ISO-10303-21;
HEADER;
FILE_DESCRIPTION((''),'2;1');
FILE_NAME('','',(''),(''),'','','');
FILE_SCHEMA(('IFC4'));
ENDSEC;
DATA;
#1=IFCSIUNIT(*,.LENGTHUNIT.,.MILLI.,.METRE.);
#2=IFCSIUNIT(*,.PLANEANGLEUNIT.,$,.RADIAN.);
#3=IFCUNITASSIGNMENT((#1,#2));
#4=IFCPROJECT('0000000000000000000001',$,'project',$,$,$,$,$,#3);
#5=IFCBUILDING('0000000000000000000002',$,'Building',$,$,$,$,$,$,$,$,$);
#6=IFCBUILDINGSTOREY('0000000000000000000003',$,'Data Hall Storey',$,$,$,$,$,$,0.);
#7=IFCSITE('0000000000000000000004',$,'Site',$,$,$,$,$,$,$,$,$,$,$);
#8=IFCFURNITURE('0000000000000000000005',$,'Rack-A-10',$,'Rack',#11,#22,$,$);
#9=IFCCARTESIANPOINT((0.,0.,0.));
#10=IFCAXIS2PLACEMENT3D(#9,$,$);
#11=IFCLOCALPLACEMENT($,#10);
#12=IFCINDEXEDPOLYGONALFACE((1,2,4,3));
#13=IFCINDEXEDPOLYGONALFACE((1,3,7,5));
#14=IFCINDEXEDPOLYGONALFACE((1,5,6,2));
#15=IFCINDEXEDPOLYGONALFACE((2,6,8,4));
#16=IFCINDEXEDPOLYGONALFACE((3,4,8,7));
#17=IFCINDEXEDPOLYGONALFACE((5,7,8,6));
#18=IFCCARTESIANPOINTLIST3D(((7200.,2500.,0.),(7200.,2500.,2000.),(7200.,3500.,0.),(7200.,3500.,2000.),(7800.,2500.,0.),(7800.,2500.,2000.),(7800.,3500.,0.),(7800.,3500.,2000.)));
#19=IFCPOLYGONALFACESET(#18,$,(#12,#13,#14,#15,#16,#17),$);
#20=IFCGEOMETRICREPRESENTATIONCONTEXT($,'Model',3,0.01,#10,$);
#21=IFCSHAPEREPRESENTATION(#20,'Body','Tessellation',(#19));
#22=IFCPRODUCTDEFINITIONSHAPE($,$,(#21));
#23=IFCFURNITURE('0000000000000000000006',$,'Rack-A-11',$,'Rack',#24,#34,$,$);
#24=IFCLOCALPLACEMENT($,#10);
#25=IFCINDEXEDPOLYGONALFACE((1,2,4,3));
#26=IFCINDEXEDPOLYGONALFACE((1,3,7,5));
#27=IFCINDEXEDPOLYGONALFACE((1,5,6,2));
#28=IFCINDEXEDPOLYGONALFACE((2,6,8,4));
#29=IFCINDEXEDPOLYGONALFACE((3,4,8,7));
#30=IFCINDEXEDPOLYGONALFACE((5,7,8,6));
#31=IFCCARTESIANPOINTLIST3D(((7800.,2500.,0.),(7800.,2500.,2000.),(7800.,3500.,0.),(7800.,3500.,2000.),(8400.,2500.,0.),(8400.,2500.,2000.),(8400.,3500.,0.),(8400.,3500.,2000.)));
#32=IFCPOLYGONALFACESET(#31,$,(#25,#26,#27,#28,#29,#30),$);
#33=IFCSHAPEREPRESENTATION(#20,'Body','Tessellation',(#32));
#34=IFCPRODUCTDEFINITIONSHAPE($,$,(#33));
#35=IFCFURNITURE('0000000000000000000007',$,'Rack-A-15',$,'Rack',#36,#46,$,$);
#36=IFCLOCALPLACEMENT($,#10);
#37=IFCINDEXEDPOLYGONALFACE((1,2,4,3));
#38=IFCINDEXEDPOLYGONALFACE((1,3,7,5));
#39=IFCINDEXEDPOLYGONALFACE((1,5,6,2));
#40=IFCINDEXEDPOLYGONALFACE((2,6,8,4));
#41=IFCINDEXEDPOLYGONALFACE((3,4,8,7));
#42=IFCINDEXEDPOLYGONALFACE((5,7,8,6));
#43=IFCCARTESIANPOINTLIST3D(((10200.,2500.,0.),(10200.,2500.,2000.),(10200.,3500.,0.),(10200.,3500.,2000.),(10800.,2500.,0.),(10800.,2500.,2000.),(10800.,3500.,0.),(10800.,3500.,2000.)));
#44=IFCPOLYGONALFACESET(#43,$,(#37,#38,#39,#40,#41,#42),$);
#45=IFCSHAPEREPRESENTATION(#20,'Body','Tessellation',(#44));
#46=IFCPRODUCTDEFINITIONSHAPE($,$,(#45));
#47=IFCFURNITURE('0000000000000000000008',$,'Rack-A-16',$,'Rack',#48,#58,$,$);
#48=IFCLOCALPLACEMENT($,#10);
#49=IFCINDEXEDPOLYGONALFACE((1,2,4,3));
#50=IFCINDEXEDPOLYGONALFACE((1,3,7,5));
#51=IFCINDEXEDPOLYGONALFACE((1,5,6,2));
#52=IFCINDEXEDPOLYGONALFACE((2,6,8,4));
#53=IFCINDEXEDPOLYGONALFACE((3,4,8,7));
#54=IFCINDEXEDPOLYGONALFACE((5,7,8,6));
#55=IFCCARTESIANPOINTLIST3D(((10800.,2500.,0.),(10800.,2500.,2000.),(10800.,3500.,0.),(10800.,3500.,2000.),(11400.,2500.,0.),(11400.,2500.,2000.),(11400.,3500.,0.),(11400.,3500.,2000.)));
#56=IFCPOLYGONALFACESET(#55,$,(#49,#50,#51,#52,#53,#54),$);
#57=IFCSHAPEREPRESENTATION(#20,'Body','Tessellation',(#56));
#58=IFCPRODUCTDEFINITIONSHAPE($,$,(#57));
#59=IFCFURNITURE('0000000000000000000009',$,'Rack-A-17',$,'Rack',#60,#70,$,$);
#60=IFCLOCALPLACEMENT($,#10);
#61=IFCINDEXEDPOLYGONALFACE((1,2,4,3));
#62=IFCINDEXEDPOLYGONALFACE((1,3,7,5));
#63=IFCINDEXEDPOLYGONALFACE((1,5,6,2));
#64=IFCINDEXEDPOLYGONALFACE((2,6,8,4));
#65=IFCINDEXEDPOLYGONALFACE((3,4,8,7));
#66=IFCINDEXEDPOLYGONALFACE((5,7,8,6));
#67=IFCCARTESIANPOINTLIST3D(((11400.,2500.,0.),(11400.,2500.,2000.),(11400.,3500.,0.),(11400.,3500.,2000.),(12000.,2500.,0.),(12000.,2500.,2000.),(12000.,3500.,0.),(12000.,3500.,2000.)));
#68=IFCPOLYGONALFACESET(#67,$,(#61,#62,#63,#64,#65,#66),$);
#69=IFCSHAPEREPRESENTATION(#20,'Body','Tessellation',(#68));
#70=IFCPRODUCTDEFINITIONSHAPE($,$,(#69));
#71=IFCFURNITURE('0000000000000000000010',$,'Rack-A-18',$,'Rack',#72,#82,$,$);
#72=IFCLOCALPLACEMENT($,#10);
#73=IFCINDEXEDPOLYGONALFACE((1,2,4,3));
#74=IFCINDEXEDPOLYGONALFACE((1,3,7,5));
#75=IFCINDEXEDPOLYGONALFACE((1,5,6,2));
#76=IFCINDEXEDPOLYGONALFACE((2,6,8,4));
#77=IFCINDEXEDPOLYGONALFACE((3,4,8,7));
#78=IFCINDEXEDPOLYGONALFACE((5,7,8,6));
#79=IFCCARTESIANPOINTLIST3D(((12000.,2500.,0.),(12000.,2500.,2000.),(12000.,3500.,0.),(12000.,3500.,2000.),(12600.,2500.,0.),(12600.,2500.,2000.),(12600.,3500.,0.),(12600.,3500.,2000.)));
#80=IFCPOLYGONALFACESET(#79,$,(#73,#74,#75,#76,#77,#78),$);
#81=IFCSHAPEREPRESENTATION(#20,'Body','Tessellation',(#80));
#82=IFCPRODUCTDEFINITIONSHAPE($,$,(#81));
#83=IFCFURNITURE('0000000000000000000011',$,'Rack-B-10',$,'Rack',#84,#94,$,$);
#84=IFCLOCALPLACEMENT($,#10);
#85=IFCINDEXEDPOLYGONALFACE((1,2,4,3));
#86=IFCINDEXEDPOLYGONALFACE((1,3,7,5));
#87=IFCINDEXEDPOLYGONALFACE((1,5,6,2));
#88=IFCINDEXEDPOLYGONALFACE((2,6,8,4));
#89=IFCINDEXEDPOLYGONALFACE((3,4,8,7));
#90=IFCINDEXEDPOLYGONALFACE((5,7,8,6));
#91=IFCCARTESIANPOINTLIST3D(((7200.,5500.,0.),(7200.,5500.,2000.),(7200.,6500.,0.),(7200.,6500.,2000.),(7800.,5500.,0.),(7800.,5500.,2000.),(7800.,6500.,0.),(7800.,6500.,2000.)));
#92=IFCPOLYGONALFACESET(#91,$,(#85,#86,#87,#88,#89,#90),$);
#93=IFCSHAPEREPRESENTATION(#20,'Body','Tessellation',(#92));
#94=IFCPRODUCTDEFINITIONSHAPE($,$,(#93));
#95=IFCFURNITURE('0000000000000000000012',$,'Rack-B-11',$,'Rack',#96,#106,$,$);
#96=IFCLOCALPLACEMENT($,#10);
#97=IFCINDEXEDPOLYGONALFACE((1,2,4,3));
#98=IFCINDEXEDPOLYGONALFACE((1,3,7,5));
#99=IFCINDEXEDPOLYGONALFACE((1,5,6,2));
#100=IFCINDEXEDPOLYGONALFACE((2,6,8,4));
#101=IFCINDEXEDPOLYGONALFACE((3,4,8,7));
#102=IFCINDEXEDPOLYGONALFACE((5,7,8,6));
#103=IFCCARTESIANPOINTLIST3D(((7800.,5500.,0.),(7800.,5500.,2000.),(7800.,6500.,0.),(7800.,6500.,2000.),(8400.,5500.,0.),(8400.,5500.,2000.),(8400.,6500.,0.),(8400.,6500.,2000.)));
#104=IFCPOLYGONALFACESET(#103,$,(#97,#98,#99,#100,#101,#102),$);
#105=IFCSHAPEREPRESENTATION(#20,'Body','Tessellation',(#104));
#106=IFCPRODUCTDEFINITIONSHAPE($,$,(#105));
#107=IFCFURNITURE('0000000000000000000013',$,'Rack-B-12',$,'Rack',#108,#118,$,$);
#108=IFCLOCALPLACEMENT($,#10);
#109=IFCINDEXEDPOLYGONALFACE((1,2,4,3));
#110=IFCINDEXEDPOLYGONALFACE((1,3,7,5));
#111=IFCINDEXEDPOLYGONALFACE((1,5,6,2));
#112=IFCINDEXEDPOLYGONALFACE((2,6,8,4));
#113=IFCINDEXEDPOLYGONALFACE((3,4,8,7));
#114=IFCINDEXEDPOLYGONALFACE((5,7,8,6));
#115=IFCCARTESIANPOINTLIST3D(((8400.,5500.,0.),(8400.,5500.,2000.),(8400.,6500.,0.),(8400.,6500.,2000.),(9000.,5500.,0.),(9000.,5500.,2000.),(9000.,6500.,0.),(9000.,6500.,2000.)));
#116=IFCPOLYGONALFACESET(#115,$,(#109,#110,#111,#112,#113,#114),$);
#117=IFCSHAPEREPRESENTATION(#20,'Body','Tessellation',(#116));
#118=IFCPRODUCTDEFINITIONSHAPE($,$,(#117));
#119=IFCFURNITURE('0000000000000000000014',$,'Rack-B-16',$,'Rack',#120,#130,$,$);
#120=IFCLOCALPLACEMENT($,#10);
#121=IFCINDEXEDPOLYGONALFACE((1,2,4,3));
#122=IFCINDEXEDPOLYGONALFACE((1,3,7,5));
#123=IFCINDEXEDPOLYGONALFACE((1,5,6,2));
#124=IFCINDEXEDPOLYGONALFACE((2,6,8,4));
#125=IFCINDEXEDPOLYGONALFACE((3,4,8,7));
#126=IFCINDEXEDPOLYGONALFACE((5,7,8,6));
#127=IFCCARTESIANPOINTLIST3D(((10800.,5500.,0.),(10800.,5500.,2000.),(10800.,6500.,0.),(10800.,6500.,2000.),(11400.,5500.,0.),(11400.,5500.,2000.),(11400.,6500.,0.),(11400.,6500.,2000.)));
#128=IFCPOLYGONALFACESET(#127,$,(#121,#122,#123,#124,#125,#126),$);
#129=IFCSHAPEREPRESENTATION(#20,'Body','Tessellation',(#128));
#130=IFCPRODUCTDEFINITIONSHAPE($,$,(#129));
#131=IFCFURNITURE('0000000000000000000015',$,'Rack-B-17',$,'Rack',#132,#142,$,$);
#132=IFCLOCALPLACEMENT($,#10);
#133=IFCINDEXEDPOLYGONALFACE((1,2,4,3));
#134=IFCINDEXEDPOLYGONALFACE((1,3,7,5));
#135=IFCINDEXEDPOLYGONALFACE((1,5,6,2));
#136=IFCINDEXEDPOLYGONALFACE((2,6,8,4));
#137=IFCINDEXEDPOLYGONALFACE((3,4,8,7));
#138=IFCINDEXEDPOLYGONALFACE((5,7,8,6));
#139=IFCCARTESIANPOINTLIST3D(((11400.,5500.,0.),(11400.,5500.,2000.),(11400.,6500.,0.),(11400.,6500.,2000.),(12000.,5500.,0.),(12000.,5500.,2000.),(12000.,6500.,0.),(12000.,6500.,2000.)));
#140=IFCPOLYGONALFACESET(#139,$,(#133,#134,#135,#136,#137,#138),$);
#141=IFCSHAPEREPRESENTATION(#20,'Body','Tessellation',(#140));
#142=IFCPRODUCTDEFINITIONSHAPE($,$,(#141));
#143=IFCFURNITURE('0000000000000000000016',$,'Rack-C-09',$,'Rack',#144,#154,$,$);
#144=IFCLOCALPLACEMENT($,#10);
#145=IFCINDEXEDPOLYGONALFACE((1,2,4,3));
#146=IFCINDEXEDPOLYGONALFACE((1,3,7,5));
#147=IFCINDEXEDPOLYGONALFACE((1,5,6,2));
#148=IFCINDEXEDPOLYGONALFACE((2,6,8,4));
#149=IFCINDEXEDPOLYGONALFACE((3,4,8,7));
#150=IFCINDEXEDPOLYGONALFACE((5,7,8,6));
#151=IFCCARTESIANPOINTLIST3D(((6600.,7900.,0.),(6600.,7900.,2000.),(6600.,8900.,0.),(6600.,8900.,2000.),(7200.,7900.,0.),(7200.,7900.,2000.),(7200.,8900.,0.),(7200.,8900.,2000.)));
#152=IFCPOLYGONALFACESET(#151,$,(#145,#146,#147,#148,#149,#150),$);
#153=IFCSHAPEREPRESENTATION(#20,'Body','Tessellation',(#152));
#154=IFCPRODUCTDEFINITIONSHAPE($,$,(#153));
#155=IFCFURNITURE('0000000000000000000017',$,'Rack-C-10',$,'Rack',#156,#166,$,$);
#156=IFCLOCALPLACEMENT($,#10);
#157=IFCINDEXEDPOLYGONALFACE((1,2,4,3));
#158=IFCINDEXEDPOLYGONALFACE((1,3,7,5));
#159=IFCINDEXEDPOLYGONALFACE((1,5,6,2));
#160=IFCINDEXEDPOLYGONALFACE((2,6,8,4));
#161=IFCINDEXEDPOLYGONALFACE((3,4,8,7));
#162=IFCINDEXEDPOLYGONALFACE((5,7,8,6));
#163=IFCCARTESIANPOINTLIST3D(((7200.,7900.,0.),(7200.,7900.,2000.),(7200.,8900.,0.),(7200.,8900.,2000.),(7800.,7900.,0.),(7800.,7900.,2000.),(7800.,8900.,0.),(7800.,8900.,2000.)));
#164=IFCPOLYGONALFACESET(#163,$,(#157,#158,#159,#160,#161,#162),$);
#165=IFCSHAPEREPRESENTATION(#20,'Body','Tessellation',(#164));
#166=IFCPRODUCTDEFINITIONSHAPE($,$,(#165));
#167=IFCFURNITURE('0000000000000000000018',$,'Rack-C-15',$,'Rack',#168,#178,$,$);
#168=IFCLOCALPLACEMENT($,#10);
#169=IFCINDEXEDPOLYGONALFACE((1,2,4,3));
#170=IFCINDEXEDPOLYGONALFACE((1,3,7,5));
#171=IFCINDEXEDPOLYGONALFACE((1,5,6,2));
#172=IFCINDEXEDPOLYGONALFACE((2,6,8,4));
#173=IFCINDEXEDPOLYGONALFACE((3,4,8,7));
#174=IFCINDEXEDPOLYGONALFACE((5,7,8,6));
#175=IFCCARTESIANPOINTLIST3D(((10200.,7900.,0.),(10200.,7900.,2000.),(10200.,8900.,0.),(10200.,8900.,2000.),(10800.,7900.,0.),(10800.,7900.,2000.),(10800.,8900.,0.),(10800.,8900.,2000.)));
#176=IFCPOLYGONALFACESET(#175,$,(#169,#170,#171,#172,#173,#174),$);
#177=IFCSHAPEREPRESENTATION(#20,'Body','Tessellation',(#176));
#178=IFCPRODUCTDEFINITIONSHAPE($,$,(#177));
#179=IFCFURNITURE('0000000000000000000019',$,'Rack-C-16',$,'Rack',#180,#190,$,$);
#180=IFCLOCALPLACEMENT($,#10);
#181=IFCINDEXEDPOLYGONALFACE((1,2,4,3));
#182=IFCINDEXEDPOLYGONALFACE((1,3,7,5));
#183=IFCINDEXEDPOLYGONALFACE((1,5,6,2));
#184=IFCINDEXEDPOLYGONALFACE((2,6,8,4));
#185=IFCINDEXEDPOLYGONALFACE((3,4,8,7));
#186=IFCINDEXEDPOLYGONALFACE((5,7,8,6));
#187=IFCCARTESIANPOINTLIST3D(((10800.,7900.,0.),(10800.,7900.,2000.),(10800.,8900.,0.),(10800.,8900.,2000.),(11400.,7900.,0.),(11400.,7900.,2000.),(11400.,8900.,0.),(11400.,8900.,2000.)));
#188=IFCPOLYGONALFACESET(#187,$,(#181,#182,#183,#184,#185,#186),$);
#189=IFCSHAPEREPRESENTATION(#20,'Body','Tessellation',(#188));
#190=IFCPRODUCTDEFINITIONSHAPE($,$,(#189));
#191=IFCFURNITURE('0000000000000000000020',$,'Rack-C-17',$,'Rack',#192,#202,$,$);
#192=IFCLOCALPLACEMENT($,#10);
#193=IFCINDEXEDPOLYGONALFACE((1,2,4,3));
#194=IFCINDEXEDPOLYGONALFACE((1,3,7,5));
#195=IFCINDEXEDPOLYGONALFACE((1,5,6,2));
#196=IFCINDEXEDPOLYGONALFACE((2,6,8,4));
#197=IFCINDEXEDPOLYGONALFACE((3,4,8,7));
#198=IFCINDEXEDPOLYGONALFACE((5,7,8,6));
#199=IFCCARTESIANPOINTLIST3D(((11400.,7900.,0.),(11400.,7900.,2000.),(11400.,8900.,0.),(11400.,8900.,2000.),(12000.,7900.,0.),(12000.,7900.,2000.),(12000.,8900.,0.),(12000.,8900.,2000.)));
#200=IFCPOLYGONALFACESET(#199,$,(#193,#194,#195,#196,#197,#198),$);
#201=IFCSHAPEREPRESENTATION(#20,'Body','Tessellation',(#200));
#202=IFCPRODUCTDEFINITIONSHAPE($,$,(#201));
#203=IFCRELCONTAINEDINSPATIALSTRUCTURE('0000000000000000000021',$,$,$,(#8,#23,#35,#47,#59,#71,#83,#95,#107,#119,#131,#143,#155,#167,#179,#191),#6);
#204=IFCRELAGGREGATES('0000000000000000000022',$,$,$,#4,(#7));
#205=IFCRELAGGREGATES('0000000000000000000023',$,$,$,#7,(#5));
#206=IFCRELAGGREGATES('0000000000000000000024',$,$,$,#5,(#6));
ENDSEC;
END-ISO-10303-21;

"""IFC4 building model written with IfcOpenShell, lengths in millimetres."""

from ifc_helpers import new_model, si_unit, frame, origin, place, context, project, spatial, rectangle, extrude, element, save


model = new_model("IFC4")

# Units and contexts
model_context = context("Model", 3, precision=0.01, world=origin())
ifc_project = project(units=[si_unit("LENGTHUNIT", "METRE", prefix="MILLI"), si_unit("PLANEANGLEUNIT", "RADIAN")])

# Site, building, storey
site = spatial("IfcSite", under=ifc_project, Name="Site")
building = spatial("IfcBuilding", under=site, Name="Building")
storey = spatial("IfcBuildingStorey", under=building, Name="Data Hall Storey", Elevation=0.0)

# Furniture
for number, where, name in (
    (1, (7500.0, 3000.0, 0.0), "Rack-A-10"),
    (2, (8100.0, 3000.0, 0.0), "Rack-A-11"),
    (3, (10500.0, 3000.0, 0.0), "Rack-A-15"),
    (4, (11100.0, 3000.0, 0.0), "Rack-A-16"),
    (5, (11700.0, 3000.0, 0.0), "Rack-A-17"),
    (6, (12300.0, 3000.0, 0.0), "Rack-A-18"),
    (7, (7500.0, 6000.0, 0.0), "Rack-B-10"),
    (8, (8100.0, 6000.0, 0.0), "Rack-B-11"),
    (9, (8700.0, 6000.0, 0.0), "Rack-B-12"),
    (10, (11100.0, 6000.0, 0.0), "Rack-B-16"),
    (11, (11700.0, 6000.0, 0.0), "Rack-B-17"),
    (12, (6900.0, 8400.0, 0.0), "Rack-C-09"),
    (13, (7500.0, 8400.0, 0.0), "Rack-C-10"),
    (14, (10500.0, 8400.0, 0.0), "Rack-C-15"),
    (15, (11100.0, 8400.0, 0.0), "Rack-C-16"),
    (16, (11700.0, 8400.0, 0.0), "Rack-C-17"),
):
    element("IfcFurniture", number, at=place(None, frame(where)), inside=storey, Name=name, ObjectType="Rack", context=model_context, shape_type="SweptSolid", body=[
        extrude(rectangle(XDim=600.0, YDim=1000.0), origin(), (0.0, 0.0, 1.0), 2000.0),
    ])

save(model, "model.ifc")
